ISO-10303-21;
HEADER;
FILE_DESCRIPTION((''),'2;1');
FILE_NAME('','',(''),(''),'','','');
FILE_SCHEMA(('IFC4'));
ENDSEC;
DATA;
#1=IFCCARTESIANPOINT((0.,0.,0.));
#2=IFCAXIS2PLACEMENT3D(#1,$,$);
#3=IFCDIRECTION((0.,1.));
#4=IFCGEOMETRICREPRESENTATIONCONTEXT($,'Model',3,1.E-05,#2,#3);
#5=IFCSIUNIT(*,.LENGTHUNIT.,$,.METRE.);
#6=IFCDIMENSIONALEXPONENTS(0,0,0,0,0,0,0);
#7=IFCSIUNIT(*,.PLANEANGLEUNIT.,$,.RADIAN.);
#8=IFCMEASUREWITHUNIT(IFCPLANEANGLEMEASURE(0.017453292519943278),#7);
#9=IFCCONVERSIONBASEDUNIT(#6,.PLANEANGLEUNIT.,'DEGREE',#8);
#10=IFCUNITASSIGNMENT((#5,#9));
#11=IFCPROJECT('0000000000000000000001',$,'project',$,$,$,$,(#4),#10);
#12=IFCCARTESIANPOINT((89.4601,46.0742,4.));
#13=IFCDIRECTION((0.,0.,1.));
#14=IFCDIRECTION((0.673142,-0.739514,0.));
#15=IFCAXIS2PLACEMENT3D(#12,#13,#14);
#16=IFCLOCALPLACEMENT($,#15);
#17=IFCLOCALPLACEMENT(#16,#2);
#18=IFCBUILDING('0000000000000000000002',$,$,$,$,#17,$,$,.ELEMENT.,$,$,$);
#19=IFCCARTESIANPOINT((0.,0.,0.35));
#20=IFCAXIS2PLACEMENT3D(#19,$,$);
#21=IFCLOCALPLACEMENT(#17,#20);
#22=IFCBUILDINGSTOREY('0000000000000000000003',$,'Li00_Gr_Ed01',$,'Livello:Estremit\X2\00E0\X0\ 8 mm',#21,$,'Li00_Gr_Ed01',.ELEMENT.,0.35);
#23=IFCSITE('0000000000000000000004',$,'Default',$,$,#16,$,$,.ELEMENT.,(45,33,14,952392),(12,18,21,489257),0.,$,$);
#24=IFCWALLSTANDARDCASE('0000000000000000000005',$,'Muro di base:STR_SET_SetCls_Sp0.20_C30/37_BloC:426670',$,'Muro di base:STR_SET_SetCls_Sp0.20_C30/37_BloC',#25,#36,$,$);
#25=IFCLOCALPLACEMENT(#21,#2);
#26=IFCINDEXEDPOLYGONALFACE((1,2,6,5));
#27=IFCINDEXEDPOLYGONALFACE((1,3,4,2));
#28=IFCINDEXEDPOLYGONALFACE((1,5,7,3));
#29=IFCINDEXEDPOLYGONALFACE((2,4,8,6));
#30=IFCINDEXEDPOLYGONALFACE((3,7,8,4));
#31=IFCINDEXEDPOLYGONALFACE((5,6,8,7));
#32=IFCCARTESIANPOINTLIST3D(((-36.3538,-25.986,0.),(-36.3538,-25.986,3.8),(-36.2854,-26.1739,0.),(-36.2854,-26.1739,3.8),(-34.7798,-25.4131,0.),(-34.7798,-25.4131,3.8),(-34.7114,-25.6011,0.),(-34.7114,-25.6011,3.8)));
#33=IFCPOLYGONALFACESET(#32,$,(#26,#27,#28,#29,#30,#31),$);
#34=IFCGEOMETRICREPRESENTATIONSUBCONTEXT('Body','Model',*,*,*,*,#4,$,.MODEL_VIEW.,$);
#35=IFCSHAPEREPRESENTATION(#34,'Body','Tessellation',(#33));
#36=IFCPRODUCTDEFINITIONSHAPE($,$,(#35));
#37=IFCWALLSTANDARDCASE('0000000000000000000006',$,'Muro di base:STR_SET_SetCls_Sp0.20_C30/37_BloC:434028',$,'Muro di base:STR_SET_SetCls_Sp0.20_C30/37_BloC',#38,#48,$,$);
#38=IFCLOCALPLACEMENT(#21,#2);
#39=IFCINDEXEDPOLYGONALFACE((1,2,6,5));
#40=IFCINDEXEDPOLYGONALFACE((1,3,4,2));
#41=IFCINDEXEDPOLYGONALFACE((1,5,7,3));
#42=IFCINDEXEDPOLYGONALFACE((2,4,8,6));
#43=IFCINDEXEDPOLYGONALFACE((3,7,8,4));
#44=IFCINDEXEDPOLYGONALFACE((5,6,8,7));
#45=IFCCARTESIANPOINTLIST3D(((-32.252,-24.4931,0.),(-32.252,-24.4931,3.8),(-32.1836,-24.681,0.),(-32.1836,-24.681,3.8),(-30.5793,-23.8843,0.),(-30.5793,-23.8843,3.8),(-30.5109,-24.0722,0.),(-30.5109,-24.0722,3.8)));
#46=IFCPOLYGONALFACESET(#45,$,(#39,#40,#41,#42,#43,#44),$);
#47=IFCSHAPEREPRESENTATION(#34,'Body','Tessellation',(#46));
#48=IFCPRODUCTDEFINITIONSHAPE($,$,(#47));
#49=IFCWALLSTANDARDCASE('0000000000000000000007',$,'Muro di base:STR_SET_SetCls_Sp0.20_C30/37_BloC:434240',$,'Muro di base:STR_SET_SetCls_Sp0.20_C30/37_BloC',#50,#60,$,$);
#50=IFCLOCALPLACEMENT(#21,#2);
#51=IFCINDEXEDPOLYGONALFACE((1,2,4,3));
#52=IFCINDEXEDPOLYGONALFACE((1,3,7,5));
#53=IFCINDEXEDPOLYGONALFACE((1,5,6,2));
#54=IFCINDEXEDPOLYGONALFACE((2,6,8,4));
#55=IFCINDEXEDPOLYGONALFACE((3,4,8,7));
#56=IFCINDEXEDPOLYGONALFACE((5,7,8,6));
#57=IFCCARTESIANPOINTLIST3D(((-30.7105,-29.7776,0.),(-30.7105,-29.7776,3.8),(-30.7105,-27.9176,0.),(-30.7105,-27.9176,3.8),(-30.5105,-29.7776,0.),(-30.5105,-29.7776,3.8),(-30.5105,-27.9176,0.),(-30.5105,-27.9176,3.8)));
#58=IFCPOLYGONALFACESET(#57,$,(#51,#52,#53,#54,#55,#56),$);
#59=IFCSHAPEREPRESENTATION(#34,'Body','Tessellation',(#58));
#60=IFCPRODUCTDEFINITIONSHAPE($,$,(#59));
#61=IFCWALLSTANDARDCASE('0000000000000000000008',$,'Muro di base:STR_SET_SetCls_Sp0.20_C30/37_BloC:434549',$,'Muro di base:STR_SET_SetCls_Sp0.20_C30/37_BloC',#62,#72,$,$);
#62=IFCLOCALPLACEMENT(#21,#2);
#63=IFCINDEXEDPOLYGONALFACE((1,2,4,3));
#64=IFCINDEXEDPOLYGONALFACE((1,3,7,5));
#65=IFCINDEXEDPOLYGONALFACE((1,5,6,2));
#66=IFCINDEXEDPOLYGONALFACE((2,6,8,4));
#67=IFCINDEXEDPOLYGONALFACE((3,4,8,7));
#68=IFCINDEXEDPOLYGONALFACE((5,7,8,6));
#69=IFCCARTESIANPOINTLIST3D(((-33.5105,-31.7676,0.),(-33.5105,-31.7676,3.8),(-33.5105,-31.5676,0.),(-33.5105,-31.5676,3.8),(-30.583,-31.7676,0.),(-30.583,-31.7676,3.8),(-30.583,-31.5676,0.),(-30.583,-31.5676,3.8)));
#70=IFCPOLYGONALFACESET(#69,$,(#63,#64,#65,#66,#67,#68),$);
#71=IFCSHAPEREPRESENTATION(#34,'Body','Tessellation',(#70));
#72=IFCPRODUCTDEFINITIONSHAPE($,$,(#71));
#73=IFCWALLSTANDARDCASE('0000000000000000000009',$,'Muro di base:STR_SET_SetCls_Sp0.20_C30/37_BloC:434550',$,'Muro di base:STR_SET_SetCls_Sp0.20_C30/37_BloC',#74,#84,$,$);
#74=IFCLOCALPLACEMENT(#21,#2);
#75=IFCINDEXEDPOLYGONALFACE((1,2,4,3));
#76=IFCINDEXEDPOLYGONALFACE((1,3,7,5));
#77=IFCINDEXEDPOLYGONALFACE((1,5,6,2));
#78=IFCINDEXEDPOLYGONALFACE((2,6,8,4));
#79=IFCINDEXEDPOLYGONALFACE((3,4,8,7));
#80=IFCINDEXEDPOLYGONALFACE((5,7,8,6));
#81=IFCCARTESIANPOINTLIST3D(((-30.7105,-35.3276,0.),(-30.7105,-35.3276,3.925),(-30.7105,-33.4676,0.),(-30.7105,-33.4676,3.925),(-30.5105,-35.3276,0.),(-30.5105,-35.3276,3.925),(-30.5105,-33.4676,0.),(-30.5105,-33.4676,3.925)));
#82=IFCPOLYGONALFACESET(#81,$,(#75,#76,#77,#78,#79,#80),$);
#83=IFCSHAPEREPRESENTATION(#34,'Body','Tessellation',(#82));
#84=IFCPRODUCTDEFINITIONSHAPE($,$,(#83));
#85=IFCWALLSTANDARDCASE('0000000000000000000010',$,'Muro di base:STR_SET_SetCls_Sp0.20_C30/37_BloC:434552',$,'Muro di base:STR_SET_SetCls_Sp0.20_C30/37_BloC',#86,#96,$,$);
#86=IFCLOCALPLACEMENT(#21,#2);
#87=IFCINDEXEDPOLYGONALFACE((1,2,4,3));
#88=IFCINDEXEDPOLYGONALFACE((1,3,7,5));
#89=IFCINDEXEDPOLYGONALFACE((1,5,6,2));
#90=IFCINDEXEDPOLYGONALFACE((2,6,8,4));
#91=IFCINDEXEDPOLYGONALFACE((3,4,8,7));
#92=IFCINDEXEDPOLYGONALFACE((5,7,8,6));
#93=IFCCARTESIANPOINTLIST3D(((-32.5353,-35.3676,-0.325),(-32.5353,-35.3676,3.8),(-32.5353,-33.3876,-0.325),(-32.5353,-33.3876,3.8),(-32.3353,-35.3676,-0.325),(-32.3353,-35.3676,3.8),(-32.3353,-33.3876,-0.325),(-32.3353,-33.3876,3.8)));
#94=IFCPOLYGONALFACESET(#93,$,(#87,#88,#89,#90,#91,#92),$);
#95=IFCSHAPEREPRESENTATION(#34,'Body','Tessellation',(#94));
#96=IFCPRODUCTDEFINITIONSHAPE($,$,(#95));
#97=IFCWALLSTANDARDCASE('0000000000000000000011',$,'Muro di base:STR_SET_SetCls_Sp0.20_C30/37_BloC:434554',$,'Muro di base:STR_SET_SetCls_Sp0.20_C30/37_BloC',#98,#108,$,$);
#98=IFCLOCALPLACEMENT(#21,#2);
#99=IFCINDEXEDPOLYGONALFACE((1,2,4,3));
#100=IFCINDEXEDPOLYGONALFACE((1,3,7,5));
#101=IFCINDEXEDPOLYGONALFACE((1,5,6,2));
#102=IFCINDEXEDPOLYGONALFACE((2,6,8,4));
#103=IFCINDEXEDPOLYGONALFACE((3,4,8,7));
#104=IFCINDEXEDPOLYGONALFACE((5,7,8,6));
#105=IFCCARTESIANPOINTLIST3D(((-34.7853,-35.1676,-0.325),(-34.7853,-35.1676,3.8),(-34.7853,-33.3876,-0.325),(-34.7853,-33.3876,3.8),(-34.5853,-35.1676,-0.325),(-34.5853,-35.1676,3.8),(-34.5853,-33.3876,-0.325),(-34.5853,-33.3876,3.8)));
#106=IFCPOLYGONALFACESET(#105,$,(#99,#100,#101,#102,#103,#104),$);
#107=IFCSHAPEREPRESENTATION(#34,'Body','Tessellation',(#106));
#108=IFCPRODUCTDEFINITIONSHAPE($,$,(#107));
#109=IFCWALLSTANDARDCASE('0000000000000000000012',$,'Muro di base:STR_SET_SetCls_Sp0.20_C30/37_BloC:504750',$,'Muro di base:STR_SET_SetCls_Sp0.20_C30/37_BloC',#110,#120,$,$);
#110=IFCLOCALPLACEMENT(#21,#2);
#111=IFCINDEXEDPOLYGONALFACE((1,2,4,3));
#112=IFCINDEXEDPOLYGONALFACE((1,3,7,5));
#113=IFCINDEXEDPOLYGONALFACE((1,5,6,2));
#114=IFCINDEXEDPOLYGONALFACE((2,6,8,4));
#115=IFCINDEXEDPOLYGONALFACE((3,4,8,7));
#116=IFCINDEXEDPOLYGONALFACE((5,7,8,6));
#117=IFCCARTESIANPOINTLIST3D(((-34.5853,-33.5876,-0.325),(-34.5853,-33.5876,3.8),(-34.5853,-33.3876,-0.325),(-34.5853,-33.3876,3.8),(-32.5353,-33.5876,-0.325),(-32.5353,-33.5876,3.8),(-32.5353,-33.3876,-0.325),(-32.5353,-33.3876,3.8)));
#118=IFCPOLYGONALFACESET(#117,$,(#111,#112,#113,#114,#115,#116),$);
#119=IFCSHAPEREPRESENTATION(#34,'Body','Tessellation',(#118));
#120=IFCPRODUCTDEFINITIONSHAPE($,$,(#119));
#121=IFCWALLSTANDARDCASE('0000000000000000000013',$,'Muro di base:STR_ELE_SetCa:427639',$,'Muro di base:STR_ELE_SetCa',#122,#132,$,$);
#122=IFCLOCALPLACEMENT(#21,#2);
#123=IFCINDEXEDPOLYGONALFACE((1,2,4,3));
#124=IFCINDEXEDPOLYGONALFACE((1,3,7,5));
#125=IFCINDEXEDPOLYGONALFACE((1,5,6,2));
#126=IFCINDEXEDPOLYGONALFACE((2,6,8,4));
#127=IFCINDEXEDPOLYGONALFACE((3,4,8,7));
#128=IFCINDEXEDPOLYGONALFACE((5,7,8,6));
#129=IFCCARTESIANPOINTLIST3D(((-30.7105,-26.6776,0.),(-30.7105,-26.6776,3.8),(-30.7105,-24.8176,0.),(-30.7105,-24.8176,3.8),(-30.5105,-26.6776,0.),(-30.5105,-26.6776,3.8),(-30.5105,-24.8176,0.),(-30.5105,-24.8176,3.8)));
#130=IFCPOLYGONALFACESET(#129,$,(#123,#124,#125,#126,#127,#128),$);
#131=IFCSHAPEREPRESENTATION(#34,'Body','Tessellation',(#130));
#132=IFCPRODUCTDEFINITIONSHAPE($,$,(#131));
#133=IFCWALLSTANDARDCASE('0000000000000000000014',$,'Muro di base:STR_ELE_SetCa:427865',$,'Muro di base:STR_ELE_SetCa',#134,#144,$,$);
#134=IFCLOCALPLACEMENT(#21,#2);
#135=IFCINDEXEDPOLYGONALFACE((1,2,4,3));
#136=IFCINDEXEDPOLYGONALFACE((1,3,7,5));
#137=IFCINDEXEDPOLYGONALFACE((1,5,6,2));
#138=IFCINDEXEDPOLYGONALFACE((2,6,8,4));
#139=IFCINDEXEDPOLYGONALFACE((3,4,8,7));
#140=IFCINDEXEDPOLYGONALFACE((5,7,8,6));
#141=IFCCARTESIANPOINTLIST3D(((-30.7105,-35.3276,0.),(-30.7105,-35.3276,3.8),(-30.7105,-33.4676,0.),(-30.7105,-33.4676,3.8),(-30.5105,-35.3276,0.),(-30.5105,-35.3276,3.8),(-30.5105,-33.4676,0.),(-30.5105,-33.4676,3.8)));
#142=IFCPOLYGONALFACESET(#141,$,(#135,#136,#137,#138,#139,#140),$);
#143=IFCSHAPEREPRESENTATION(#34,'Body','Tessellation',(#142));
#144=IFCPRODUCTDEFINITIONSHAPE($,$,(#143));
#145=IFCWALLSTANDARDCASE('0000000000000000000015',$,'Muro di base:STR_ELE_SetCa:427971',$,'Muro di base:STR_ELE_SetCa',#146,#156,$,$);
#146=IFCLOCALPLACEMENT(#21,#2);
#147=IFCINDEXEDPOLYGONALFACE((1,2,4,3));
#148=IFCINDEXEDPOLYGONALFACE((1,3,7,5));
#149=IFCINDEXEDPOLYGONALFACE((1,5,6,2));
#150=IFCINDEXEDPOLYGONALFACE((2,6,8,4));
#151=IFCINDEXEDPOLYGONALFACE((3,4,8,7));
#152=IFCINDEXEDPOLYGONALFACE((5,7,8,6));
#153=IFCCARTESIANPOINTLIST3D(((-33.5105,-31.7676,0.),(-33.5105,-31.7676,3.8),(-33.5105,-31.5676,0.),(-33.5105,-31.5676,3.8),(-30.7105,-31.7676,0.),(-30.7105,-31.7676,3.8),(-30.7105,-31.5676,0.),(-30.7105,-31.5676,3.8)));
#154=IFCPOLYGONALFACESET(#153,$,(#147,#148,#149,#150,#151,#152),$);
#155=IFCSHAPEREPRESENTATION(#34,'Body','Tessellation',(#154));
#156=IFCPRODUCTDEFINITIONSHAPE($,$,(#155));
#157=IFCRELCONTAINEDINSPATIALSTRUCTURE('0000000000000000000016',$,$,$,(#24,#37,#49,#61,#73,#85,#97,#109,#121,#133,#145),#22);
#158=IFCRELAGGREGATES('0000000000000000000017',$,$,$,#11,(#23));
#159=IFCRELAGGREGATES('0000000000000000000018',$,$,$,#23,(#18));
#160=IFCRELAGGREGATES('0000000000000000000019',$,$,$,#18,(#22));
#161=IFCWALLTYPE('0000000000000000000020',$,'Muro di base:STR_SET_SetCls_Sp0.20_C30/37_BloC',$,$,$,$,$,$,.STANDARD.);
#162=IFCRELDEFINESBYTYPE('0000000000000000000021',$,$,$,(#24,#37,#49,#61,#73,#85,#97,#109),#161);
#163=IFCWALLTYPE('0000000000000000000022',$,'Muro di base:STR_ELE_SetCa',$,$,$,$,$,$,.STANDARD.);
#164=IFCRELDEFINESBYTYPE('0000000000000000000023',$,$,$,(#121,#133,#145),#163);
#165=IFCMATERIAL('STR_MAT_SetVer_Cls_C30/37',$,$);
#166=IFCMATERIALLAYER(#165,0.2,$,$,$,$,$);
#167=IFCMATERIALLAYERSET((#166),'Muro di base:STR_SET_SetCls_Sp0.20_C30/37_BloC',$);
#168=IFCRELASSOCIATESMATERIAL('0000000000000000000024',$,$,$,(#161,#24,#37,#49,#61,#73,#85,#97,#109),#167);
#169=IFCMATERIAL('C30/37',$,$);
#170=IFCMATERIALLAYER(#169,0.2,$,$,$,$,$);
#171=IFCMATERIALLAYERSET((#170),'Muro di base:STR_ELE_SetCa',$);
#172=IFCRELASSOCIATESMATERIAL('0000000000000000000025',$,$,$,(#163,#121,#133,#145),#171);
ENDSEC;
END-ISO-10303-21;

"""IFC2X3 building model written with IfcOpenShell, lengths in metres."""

from ifc_helpers import new_model, entity, si_unit, converted_unit, direction, frame, frame_2d, origin, place, context, subcontext, project, spatial, rectangle, extrude, material, layer, layer_set, layer_usage, type_object, element, save


model = new_model("IFC2X3")

# Units and contexts
model_context = context("Model", 3, precision=1e-05, world=origin(), true_north=direction((0.0, 1.0)))
body_context = subcontext(model_context, "Body", "Model", "MODEL_VIEW")
ifc_project = project(units=[si_unit("LENGTHUNIT", "METRE"), converted_unit("PLANEANGLEUNIT", "DEGREE", entity("IfcPlaneAngleMeasure", 0.017453292519943278), si_unit("PLANEANGLEUNIT", "RADIAN"), dimensions=[0, 0, 0, 0, 0, 0, 0])], contexts=[model_context])

# Site, building, storey
site_placement = place(None, frame((89.4601, 46.0742, 4.0), z_axis=(0.0, 0.0, 1.0), x_axis=(0.673142, -0.739514, 0.0)))
site = spatial("IfcSite", under=ifc_project, at=site_placement, Name="Default", CompositionType="ELEMENT", RefLatitude=(45, 33, 14, 952392), RefLongitude=(12, 18, 21, 489257), RefElevation=0.0)
building_placement = place(site_placement, origin())
building = spatial("IfcBuilding", under=site, at=building_placement, CompositionType="ELEMENT")
storey_placement = place(building_placement, frame((0.0, 0.0, 0.35)))
storey = spatial("IfcBuildingStorey", under=building, at=storey_placement, Name="Li00_Gr_Ed01", ObjectType="Livello:Estremità 8 mm", LongName="Li00_Gr_Ed01", CompositionType="ELEMENT", Elevation=0.35)

# Shared definitions
ifc_material_1 = material(Name="C30/37")

# Walls
ifc_material_2 = material(Name="STR_MAT_SetVer_Cls_C30/37")
ifc_layer_1 = layer(ifc_material_2, 0.2)
ifc_layer_set_1 = layer_set([ifc_layer_1], Name="Muro di base:STR_SET_SetCls_Sp0.20_C30/37_BloC")
ifc_layer_usage_1 = layer_usage(ifc_layer_set_1, "AXIS2", "NEGATIVE", 0.1)
wall_type_1 = type_object("IfcWallType", Name="Muro di base:STR_SET_SetCls_Sp0.20_C30/37_BloC", PredefinedType="STANDARD", material=ifc_layer_set_1)
wall_1_placement = place(storey_placement, frame((-36.3196, -26.08, 0.0), z_axis=(0.0, 0.0, 1.0), x_axis=(0.939693, 0.34202, 0.0)))
element("IfcWallStandardCase", 1, at=wall_1_placement, inside=storey, type_object=wall_type_1, material=ifc_layer_usage_1, Name="Muro di base:STR_SET_SetCls_Sp0.20_C30/37_BloC:426670", ObjectType="Muro di base:STR_SET_SetCls_Sp0.20_C30/37_BloC", context=body_context, shape_type="SweptSolid", body=[
    extrude(rectangle(XDim=1.675, YDim=0.2, at=frame_2d((0.8375, 0.0), x_axis=(-1.0, 0.0))), origin(), (0.0, 0.0, 1.0), 3.8),
])
wall_2_placement = place(storey_placement, frame((-32.2178, -24.587, 0.0), z_axis=(0.0, 0.0, 1.0), x_axis=(0.939693, 0.34202, 0.0)))
element("IfcWallStandardCase", 2, at=wall_2_placement, inside=storey, type_object=wall_type_1, material=ifc_layer_usage_1, Name="Muro di base:STR_SET_SetCls_Sp0.20_C30/37_BloC:434028", ObjectType="Muro di base:STR_SET_SetCls_Sp0.20_C30/37_BloC", context=body_context, shape_type="SweptSolid", body=[
    extrude(rectangle(XDim=1.78, YDim=0.2, at=frame_2d((0.89, 0.0), x_axis=(-1.0, 0.0))), origin(), (0.0, 0.0, 1.0), 3.8),
])
wall_3_placement = place(storey_placement, frame((-30.6105, -27.9176, 0.0), z_axis=(0.0, 0.0, 1.0), x_axis=(0.0, -1.0, 0.0)))
element("IfcWallStandardCase", 3, at=wall_3_placement, inside=storey, type_object=wall_type_1, material=ifc_layer_usage_1, Name="Muro di base:STR_SET_SetCls_Sp0.20_C30/37_BloC:434240", ObjectType="Muro di base:STR_SET_SetCls_Sp0.20_C30/37_BloC", context=body_context, shape_type="SweptSolid", body=[
    extrude(rectangle(XDim=1.86, YDim=0.2, at=frame_2d((0.93, 0.0), x_axis=(-1.0, 0.0))), origin(), (0.0, 0.0, 1.0), 3.8),
])
wall_4_placement = place(storey_placement, frame((-33.5105, -31.6676, 0.0)))
element("IfcWallStandardCase", 4, at=wall_4_placement, inside=storey, type_object=wall_type_1, material=ifc_layer_usage_1, Name="Muro di base:STR_SET_SetCls_Sp0.20_C30/37_BloC:434549", ObjectType="Muro di base:STR_SET_SetCls_Sp0.20_C30/37_BloC", context=body_context, shape_type="SweptSolid", body=[
    extrude(rectangle(XDim=2.9275, YDim=0.2, at=frame_2d((1.4638, 0.0), x_axis=(-1.0, 0.0))), origin(), (0.0, 0.0, 1.0), 3.8),
])
wall_5_placement = place(storey_placement, frame((-30.6105, -33.4676, 0.0), z_axis=(0.0, 0.0, 1.0), x_axis=(0.0, -1.0, 0.0)))
element("IfcWallStandardCase", 5, at=wall_5_placement, inside=storey, type_object=wall_type_1, material=ifc_layer_usage_1, Name="Muro di base:STR_SET_SetCls_Sp0.20_C30/37_BloC:434550", ObjectType="Muro di base:STR_SET_SetCls_Sp0.20_C30/37_BloC", context=body_context, shape_type="SweptSolid", body=[
    extrude(rectangle(XDim=1.86, YDim=0.2, at=frame_2d((0.93, 0.0), x_axis=(-1.0, 0.0))), origin(), (0.0, 0.0, 1.0), 3.925),
])
wall_6_placement = place(storey_placement, frame((-32.4353, -35.3676, -0.325), z_axis=(0.0, 0.0, 1.0), x_axis=(0.0, 1.0, 0.0)))
element("IfcWallStandardCase", 6, at=wall_6_placement, inside=storey, type_object=wall_type_1, material=ifc_layer_usage_1, Name="Muro di base:STR_SET_SetCls_Sp0.20_C30/37_BloC:434552", ObjectType="Muro di base:STR_SET_SetCls_Sp0.20_C30/37_BloC", context=body_context, shape_type="SweptSolid", body=[
    extrude(rectangle(XDim=1.98, YDim=0.2, at=frame_2d((0.99, 0.0), x_axis=(-1.0, 0.0))), origin(), (0.0, 0.0, 1.0), 4.125),
])
wall_7_placement = place(storey_placement, frame((-34.6853, -33.3876, -0.325), z_axis=(0.0, 0.0, 1.0), x_axis=(0.0, -1.0, 0.0)))
element("IfcWallStandardCase", 7, at=wall_7_placement, inside=storey, type_object=wall_type_1, material=ifc_layer_usage_1, Name="Muro di base:STR_SET_SetCls_Sp0.20_C30/37_BloC:434554", ObjectType="Muro di base:STR_SET_SetCls_Sp0.20_C30/37_BloC", context=body_context, shape_type="SweptSolid", body=[
    extrude(rectangle(XDim=1.78, YDim=0.2, at=frame_2d((0.89, 0.0), x_axis=(-1.0, 0.0))), origin(), (0.0, 0.0, 1.0), 4.125),
])
wall_8_placement = place(storey_placement, frame((-32.5353, -33.4876, -0.325), z_axis=(0.0, 0.0, 1.0), x_axis=(-1.0, 0.0, 0.0)))
element("IfcWallStandardCase", 8, at=wall_8_placement, inside=storey, type_object=wall_type_1, material=ifc_layer_usage_1, Name="Muro di base:STR_SET_SetCls_Sp0.20_C30/37_BloC:504750", ObjectType="Muro di base:STR_SET_SetCls_Sp0.20_C30/37_BloC", context=body_context, shape_type="SweptSolid", body=[
    extrude(rectangle(XDim=2.05, YDim=0.2, at=frame_2d((1.025, 0.0), x_axis=(-1.0, 0.0))), origin(), (0.0, 0.0, 1.0), 4.125),
])
ifc_layer_2 = layer(ifc_material_1, 0.2)
ifc_layer_set_2 = layer_set([ifc_layer_2], Name="Muro di base:STR_ELE_SetCa")
ifc_layer_usage_2 = layer_usage(ifc_layer_set_2, "AXIS2", "NEGATIVE", 0.1)
wall_type_2 = type_object("IfcWallType", Name="Muro di base:STR_ELE_SetCa", PredefinedType="STANDARD", material=ifc_layer_set_2)
wall_9_placement = place(storey_placement, frame((-30.6105, -24.8176, 0.0), z_axis=(0.0, 0.0, 1.0), x_axis=(0.0, -1.0, 0.0)))
element("IfcWallStandardCase", 9, at=wall_9_placement, inside=storey, type_object=wall_type_2, material=ifc_layer_usage_2, Name="Muro di base:STR_ELE_SetCa:427639", ObjectType="Muro di base:STR_ELE_SetCa", context=body_context, shape_type="SweptSolid", body=[
    extrude(rectangle(XDim=1.86, YDim=0.2, at=frame_2d((0.93, 0.0), x_axis=(-1.0, 0.0))), origin(), (0.0, 0.0, 1.0), 3.8),
])
for number, where, z_axis, x_axis, name in (
    (10, (-30.6105, -33.4676, 0.0), (0.0, 0.0, 1.0), (0.0, -1.0, 0.0), "Muro di base:STR_ELE_SetCa:427865"),
):
    element("IfcWallStandardCase", number, at=place(storey_placement, frame(where, z_axis=z_axis, x_axis=x_axis)), inside=storey, type_object=wall_type_2, material=ifc_layer_usage_2, Name=name, ObjectType="Muro di base:STR_ELE_SetCa", context=body_context, shape_type="SweptSolid", body=[
        extrude(rectangle(XDim=1.86, YDim=0.2, at=frame_2d((0.93, 0.0), x_axis=(-1.0, 0.0))), origin(), (0.0, 0.0, 1.0), 3.8),
    ])
wall_10_placement = place(storey_placement, frame((-33.5105, -31.6676, 0.0)))
element("IfcWallStandardCase", 11, at=wall_10_placement, inside=storey, type_object=wall_type_2, material=ifc_layer_usage_2, Name="Muro di base:STR_ELE_SetCa:427971", ObjectType="Muro di base:STR_ELE_SetCa", context=body_context, shape_type="SweptSolid", body=[
    extrude(rectangle(XDim=2.8, YDim=0.2, at=frame_2d((1.4, 0.0), x_axis=(-1.0, 0.0))), origin(), (0.0, 0.0, 1.0), 3.8),
])

save(model, "model.ifc")
